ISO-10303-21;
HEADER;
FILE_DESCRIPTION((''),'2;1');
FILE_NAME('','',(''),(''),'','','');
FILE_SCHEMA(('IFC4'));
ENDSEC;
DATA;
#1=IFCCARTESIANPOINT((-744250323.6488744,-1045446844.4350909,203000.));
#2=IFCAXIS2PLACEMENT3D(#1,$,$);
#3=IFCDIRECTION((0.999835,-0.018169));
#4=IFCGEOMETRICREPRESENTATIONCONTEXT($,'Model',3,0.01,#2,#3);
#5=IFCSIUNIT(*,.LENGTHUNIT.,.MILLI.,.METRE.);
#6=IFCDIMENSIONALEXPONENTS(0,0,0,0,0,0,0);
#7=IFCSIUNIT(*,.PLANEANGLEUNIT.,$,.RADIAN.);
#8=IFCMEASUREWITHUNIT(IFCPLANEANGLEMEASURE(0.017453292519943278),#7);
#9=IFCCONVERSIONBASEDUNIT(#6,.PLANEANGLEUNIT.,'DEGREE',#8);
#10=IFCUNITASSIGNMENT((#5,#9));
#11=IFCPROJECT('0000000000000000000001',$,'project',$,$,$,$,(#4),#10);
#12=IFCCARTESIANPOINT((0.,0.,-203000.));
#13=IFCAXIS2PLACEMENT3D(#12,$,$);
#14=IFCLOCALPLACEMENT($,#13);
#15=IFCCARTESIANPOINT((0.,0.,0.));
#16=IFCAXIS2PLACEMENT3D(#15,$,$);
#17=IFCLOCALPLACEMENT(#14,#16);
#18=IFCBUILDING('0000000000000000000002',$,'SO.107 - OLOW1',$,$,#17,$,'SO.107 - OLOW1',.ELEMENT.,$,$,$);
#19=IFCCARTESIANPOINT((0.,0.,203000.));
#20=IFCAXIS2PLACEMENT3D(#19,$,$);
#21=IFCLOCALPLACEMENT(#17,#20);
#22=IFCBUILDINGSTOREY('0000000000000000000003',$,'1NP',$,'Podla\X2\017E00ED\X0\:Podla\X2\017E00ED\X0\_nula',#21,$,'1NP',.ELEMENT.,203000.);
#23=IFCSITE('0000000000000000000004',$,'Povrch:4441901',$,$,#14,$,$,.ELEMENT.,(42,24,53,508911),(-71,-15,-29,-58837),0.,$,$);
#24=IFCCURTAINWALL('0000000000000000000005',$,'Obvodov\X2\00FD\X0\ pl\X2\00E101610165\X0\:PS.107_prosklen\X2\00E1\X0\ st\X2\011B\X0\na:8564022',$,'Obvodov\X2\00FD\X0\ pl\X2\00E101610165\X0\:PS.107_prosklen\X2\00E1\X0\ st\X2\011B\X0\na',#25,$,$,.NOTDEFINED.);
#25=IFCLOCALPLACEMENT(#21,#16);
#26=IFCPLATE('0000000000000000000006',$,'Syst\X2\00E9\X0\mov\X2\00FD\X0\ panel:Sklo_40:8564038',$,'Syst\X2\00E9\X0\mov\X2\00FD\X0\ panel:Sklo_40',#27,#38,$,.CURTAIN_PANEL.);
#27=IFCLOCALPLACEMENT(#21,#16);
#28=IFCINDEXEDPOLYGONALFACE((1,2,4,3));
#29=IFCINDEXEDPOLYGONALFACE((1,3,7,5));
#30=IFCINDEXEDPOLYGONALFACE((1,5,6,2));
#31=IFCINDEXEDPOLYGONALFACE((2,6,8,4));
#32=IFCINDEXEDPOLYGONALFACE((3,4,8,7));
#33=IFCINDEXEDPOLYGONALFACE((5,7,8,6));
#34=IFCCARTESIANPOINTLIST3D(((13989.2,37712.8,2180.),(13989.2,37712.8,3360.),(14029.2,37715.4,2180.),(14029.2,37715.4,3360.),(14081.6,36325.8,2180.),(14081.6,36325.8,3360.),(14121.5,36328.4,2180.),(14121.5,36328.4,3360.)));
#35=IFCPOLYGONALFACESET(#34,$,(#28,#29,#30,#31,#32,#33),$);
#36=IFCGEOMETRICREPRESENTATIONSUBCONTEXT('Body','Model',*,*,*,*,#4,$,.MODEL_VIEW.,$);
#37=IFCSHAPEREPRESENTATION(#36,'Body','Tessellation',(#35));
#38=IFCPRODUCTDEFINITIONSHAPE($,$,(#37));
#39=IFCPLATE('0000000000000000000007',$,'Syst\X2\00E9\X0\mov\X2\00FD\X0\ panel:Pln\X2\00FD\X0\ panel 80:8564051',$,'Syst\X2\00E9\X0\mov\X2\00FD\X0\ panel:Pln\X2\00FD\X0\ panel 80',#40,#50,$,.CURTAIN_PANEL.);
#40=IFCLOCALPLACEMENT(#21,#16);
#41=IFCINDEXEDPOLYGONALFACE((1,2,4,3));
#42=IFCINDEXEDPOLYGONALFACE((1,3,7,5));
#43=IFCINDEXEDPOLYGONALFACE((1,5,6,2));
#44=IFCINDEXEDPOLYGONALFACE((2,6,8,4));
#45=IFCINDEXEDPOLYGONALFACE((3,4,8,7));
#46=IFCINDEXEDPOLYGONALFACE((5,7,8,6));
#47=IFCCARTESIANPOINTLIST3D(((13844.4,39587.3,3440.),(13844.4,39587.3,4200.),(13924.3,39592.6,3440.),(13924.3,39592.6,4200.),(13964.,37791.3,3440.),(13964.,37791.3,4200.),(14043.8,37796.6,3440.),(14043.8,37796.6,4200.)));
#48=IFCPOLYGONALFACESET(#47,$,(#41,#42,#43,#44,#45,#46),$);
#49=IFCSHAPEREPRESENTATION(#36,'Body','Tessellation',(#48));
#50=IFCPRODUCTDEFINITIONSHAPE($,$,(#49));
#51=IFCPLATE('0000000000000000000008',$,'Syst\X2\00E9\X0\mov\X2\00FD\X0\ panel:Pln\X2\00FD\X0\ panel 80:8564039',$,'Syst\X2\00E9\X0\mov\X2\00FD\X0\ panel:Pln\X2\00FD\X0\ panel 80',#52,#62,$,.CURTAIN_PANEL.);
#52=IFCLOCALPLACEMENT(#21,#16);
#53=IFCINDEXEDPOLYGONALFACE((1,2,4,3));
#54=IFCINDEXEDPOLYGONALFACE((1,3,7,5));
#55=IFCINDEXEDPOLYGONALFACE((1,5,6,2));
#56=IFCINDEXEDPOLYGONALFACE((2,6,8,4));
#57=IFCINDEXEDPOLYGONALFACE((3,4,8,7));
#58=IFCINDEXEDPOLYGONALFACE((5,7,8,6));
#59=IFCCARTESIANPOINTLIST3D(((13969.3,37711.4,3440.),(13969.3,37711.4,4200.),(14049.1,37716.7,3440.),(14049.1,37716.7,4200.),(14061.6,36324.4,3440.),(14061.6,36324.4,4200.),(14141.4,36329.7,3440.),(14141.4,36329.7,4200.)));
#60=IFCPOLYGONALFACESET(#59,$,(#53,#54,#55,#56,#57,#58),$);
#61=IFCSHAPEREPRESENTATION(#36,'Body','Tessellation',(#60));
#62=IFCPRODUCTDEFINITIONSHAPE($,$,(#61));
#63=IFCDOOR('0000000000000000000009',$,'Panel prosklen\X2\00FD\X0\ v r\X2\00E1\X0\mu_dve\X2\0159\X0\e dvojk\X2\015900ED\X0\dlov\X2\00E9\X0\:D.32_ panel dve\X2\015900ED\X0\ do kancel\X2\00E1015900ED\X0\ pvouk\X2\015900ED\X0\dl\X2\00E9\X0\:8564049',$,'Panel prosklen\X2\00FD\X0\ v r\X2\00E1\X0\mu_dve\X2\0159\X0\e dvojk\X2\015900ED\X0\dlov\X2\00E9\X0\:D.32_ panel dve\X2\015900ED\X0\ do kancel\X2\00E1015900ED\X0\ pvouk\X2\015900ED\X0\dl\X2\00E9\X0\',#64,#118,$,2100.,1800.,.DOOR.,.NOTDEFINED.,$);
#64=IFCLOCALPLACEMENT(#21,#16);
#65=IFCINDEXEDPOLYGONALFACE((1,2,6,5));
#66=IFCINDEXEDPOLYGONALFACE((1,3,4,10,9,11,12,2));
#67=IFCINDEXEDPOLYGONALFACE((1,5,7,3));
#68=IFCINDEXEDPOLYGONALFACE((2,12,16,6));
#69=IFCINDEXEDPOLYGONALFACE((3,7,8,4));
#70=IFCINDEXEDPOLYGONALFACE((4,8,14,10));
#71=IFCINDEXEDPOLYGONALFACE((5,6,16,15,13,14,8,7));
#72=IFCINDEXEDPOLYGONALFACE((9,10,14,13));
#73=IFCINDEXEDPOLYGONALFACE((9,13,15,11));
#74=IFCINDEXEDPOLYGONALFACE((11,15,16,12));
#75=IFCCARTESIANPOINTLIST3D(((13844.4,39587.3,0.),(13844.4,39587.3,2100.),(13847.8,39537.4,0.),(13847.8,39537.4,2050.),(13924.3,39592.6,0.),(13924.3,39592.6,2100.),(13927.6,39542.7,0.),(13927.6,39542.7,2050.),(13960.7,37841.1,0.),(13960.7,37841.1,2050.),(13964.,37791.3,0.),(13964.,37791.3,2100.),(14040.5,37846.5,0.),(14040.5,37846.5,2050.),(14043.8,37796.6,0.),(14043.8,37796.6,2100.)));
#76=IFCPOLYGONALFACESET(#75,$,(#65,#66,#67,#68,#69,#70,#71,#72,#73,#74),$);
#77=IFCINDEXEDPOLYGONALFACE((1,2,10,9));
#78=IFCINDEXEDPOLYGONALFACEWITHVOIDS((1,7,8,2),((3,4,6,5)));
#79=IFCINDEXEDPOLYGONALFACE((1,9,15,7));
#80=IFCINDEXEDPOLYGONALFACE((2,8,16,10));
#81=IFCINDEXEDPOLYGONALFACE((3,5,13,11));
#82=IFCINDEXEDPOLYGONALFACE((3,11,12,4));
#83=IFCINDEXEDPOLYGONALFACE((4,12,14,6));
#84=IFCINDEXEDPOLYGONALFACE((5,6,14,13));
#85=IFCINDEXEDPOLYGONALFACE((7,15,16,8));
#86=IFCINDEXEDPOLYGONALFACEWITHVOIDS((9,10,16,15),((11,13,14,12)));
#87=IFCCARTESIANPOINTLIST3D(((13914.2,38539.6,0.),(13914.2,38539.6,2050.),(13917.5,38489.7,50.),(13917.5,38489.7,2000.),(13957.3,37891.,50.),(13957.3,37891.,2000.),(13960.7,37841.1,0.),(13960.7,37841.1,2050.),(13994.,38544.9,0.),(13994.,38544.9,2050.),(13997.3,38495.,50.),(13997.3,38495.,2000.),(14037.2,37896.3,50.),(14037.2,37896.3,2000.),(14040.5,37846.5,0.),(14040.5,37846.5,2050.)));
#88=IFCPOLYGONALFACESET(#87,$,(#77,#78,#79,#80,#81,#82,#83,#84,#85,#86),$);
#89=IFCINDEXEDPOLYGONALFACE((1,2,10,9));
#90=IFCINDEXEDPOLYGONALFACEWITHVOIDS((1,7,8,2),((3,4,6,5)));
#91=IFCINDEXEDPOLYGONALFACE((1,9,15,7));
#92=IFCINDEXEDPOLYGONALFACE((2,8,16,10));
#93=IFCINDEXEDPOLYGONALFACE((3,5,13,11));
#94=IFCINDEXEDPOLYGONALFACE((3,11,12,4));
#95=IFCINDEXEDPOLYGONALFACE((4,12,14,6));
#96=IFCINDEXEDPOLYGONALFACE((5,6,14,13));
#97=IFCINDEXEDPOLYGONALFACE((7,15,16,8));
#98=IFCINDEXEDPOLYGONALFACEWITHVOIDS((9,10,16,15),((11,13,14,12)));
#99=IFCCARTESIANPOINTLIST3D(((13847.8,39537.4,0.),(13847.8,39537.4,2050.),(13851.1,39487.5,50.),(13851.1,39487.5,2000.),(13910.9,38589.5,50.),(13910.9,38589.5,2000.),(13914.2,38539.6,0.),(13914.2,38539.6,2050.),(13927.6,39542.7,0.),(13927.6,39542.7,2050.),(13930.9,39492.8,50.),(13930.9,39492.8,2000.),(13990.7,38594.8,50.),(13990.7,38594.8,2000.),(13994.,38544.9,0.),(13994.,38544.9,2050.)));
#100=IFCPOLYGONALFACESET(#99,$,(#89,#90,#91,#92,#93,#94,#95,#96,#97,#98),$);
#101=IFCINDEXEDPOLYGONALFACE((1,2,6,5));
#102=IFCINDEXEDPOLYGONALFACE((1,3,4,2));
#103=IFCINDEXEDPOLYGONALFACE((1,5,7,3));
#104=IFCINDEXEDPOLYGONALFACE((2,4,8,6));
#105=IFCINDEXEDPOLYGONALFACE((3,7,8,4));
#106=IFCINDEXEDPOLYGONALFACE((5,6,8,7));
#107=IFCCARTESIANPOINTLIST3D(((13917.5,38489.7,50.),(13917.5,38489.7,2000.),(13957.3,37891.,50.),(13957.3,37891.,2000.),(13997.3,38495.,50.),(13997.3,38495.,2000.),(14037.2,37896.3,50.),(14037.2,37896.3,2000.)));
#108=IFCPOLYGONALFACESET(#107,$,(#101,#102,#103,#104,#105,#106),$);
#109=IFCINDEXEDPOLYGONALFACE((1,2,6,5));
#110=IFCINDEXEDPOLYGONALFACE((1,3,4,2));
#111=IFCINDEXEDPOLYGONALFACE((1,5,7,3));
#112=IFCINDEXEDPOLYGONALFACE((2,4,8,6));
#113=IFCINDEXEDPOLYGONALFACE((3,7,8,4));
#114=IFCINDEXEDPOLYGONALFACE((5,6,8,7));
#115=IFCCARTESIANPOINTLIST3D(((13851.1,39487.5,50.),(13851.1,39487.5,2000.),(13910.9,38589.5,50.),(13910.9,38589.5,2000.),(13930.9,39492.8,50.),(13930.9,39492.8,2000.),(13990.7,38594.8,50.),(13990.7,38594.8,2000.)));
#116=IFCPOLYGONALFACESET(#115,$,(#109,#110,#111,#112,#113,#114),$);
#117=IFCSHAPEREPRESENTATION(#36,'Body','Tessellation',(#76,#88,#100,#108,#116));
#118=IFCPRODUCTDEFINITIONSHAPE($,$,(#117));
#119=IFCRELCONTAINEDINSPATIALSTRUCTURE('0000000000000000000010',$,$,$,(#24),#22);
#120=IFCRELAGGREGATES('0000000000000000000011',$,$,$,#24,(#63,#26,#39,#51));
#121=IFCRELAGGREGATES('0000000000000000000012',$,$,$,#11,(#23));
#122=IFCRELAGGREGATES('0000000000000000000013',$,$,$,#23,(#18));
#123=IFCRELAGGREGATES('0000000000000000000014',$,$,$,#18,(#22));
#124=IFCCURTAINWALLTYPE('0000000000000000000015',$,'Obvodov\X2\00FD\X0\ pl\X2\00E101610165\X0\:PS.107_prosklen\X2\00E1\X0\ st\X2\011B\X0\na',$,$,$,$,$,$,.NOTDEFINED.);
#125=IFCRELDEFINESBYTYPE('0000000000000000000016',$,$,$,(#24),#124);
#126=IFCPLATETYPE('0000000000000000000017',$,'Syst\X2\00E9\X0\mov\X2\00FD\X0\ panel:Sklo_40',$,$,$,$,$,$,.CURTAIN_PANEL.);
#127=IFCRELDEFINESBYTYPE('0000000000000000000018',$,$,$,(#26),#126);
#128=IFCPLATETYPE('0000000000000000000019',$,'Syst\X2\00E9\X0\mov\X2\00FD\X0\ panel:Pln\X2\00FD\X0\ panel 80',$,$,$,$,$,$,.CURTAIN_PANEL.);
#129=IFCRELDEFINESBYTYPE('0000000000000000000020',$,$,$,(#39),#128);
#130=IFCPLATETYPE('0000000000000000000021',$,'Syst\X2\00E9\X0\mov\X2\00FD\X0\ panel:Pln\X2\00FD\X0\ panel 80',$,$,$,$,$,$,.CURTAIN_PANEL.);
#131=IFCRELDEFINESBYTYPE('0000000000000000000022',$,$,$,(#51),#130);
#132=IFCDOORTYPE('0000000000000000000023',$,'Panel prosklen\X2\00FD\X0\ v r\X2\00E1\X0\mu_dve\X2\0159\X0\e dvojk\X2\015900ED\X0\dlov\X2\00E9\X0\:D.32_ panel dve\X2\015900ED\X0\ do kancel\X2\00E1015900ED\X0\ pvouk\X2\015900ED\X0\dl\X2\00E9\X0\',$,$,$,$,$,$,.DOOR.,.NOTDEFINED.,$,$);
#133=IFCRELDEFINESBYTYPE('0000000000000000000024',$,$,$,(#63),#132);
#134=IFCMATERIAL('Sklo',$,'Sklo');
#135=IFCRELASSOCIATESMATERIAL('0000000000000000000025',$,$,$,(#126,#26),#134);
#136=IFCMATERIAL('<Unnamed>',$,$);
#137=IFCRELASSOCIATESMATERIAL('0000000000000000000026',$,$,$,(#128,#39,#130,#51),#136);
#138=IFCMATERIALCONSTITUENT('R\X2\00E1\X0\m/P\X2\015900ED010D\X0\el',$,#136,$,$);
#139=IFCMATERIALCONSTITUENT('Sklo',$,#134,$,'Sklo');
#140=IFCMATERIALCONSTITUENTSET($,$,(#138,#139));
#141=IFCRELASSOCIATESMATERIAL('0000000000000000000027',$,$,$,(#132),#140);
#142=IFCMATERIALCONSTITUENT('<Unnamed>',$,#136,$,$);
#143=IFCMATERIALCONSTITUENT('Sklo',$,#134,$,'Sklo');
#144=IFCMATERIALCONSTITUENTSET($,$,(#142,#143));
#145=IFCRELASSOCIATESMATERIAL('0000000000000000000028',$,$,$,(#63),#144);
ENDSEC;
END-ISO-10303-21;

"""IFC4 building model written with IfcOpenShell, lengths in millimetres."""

from ifc_helpers import new_model, entity, si_unit, converted_unit, direction, frame, origin, place, context, subcontext, project, spatial, indexed_curve, outline, extrude, source, transform, mapped, material, constituent, constituent_set, type_object, type_shapes, element, aggregate, save


model = new_model("IFC4")

# Units and contexts
model_context = context("Model", 3, precision=0.01, world=frame((-744250323.6488744, -1045446844.4350909, 203000.0)), true_north=direction((0.999835, -0.018169)))
body_context = subcontext(model_context, "Body", "Model", "MODEL_VIEW")
ifc_project = project(units=[si_unit("LENGTHUNIT", "METRE", prefix="MILLI"), converted_unit("PLANEANGLEUNIT", "DEGREE", entity("IfcPlaneAngleMeasure", 0.017453292519943278), si_unit("PLANEANGLEUNIT", "RADIAN"), dimensions=[0, 0, 0, 0, 0, 0, 0])], contexts=[model_context])

# Site, building, storey
site_placement = place(None, frame((0.0, 0.0, -203000.0)))
site = spatial("IfcSite", under=ifc_project, at=site_placement, Name="Povrch:4441901", CompositionType="ELEMENT", RefLatitude=(42, 24, 53, 508911), RefLongitude=(-71, -15, -29, -58837), RefElevation=0.0)
building_placement = place(site_placement, origin())
building = spatial("IfcBuilding", under=site, at=building_placement, Name="SO.107 - OLOW1", LongName="SO.107 - OLOW1", CompositionType="ELEMENT")
storey_placement = place(building_placement, frame((0.0, 0.0, 203000.0)))
storey = spatial("IfcBuildingStorey", under=building, at=storey_placement, Name="1NP", ObjectType="Podlaží:Podlaží_nula", LongName="1NP", CompositionType="ELEMENT", Elevation=203000.0)

# Curtain wall, plates, door
curtain_wall_type = type_object("IfcCurtainWallType", Name="Obvodový plášť:PS.107_prosklená stěna", PredefinedType="NOTDEFINED")
curtain_wall_placement = place(storey_placement, frame((0.0, 0.0, -203000.0)))
curtain_wall = element("IfcCurtainWall", 1, at=curtain_wall_placement, inside=storey, type_object=curtain_wall_type, Name="Obvodový plášť:PS.107_prosklená stěna:8564022", ObjectType="Obvodový plášť:PS.107_prosklená stěna", PredefinedType="NOTDEFINED")
ifc_material_1 = material(Name="<Unnamed>")
ifc_material_2 = material(Name="Sklo", Category="Sklo")
plate_type_1 = type_object("IfcPlateType", Name="Systémový panel:Sklo_40", PredefinedType="CURTAIN_PANEL", material=ifc_material_2)
shared_shape_1 = source(origin(), body_context, "Body", "SweptSolid", [
    extrude(outline(indexed_curve([(-20.0, -695.0), (20.0, -695.0), (20.0, 695.0), (-20.0, 695.0), (-20.0, -695.0)], self_intersect=False)), frame((0.0, 0.0, 0.0), z_axis=(0.0, 0.0, 1.0), x_axis=(0.0, 1.0, 0.0)), (0.0, 0.0, 1.0), 1180.0),
])
type_shapes(plate_type_1, [shared_shape_1])
plate_1_placement = place(curtain_wall_placement, frame((14055.4, 37020.6, 205180.0), z_axis=(0.0, 0.0, 1.0), x_axis=(0.066409, -0.997792, 0.0)))
plate_1 = element("IfcPlate", 2, at=plate_1_placement, type_object=plate_type_1, material=ifc_material_2, Name="Systémový panel:Sklo_40:8564038", ObjectType="Systémový panel:Sklo_40", PredefinedType="CURTAIN_PANEL", context=body_context, shape_type="MappedRepresentation", body=[
    mapped(shared_shape_1, transform((0.0, 0.0, 0.0), scale=1.0)),
])
plate_type_2 = type_object("IfcPlateType", Name="Systémový panel:Plný panel 80", PredefinedType="CURTAIN_PANEL", material=ifc_material_1)
shared_shape_2 = source(origin(), body_context, "Body", "SweptSolid", [
    extrude(outline(indexed_curve([(-40.0, -900.0), (40.0, -900.0), (40.0, 900.0), (-40.0, 900.0), (-40.0, -900.0)], self_intersect=False)), frame((0.0, 0.0, 0.0), z_axis=(0.0, 0.0, 1.0), x_axis=(0.0, 1.0, 0.0)), (0.0, 0.0, 1.0), 760.0),
])
type_shapes(plate_type_2, [shared_shape_2])
plate_2_placement = place(curtain_wall_placement, frame((13944.1, 38691.9, 206440.0), z_axis=(0.0, 0.0, 1.0), x_axis=(0.066409, -0.997792, 0.0)))
plate_2 = element("IfcPlate", 3, at=plate_2_placement, type_object=plate_type_2, material=ifc_material_1, Name="Systémový panel:Plný panel 80:8564051", ObjectType="Systémový panel:Plný panel 80", PredefinedType="CURTAIN_PANEL", context=body_context, shape_type="MappedRepresentation", body=[
    mapped(shared_shape_2, transform((0.0, 0.0, 0.0), scale=1.0)),
])
plate_type_3 = type_object("IfcPlateType", Name="Systémový panel:Plný panel 80", PredefinedType="CURTAIN_PANEL", material=ifc_material_1)
shared_shape_3 = source(origin(), body_context, "Body", "SweptSolid", [
    extrude(outline(indexed_curve([(-40.0, -695.0), (40.0, -695.0), (40.0, 695.0), (-40.0, 695.0), (-40.0, -695.0)], self_intersect=False)), frame((0.0, 0.0, 0.0), z_axis=(0.0, 0.0, 1.0), x_axis=(0.0, 1.0, 0.0)), (0.0, 0.0, 1.0), 760.0),
])
type_shapes(plate_type_3, [shared_shape_3])
plate_3_placement = place(curtain_wall_placement, frame((14055.4, 37020.6, 206440.0), z_axis=(0.0, 0.0, 1.0), x_axis=(0.066409, -0.997792, 0.0)))
plate_3 = element("IfcPlate", 4, at=plate_3_placement, type_object=plate_type_3, material=ifc_material_1, Name="Systémový panel:Plný panel 80:8564039", ObjectType="Systémový panel:Plný panel 80", PredefinedType="CURTAIN_PANEL", context=body_context, shape_type="MappedRepresentation", body=[
    mapped(shared_shape_3, transform((0.0, 0.0, 0.0), scale=1.0)),
])
ifc_constituent_1 = constituent(ifc_material_1, Name="<Unnamed>")
ifc_constituent_2 = constituent(ifc_material_2, Name="Sklo", Category="Sklo")
ifc_constituent_set_1 = constituent_set(constituents=[ifc_constituent_1, ifc_constituent_2])
ifc_constituent_3 = constituent(ifc_material_1, Name="Rám/Příčel")
ifc_constituent_4 = constituent(ifc_material_2, Name="Sklo", Category="Sklo")
ifc_constituent_set_2 = constituent_set(constituents=[ifc_constituent_3, ifc_constituent_4])
door_type = type_object("IfcDoorType", Name="Panel prosklený v rámu_dveře dvojkřídlové:D.32_ panel dveří do kanceláří pvoukřídlé", OperationType="NOTDEFINED", PredefinedType="DOOR", material=ifc_constituent_set_2)
shared_shape_4 = source(origin(), body_context, "Body", "SweptSolid", [
    extrude(outline(indexed_curve([(-900.0, -1062.5), (900.0, -1062.5), (900.0, 1037.5), (850.0, 1037.5), (850.0, -1012.5), (-850.0, -1012.5), (-850.0, 1037.5), (-900.0, 1037.5), (-900.0, -1062.5)], self_intersect=False)), frame((0.0, 40.0, 1037.5), z_axis=(0.0, -1.0, 0.0), x_axis=(-1.0, 0.0, 0.0)), (0.0, 0.0, 1.0), 80.0),
    extrude(outline(indexed_curve([(-1025.0, -350.0), (1025.0, -350.0), (1025.0, 350.0), (-1025.0, 350.0), (-1025.0, -350.0)], self_intersect=False), holes=[indexed_curve([(-975.0, -300.0), (-975.0, 300.0), (975.0, 300.0), (975.0, -300.0), (-975.0, -300.0)], self_intersect=False)]), frame((-500.0, 40.0, 1025.0), z_axis=(0.0, -1.0, 0.0), x_axis=(0.0, 0.0, -1.0)), (0.0, 0.0, 1.0), 80.0),
    extrude(outline(indexed_curve([(-1025.0, -500.0), (1025.0, -500.0), (1025.0, 500.0), (-1025.0, 500.0), (-1025.0, -500.0)], self_intersect=False), holes=[indexed_curve([(-975.0, -450.0), (-975.0, 450.0), (975.0, 450.0), (975.0, -450.0), (-975.0, -450.0)], self_intersect=False)]), frame((350.0, 40.0, 1025.0), z_axis=(0.0, -1.0, 0.0), x_axis=(0.0, 0.0, -1.0)), (0.0, 0.0, 1.0), 80.0),
    extrude(outline(indexed_curve([(-300.0, -40.0), (300.0, -40.0), (300.0, 40.0), (-300.0, 40.0), (-300.0, -40.0)], self_intersect=False)), frame((-500.0, 0.0, 50.0)), (0.0, 0.0, 1.0), 1950.0),
    extrude(outline(indexed_curve([(-450.0, -40.0), (450.0, -40.0), (450.0, 40.0), (-450.0, 40.0), (-450.0, -40.0)], self_intersect=False)), frame((350.0, 0.0, 50.0)), (0.0, 0.0, 1.0), 1950.0),
])
type_shapes(door_type, [shared_shape_4])
door_placement = place(curtain_wall_placement, frame((13944.1, 38691.9, 203000.0), z_axis=(0.0, 0.0, 1.0), x_axis=(-0.066409, 0.997792, 0.0)))
door = element("IfcDoor", 5, at=door_placement, type_object=door_type, material=ifc_constituent_set_1, Name="Panel prosklený v rámu_dveře dvojkřídlové:D.32_ panel dveří do kanceláří pvoukřídlé:8564049", ObjectType="Panel prosklený v rámu_dveře dvojkřídlové:D.32_ panel dveří do kanceláří pvoukřídlé", OperationType="NOTDEFINED", OverallHeight=2100.0, OverallWidth=1800.0, PredefinedType="DOOR", context=body_context, shape_type="MappedRepresentation", body=[
    mapped(shared_shape_4, transform((0.0, 0.0, 0.0), scale=1.0)),
])
aggregate(curtain_wall, [door, plate_1, plate_2, plate_3])

save(model, "model.ifc")
